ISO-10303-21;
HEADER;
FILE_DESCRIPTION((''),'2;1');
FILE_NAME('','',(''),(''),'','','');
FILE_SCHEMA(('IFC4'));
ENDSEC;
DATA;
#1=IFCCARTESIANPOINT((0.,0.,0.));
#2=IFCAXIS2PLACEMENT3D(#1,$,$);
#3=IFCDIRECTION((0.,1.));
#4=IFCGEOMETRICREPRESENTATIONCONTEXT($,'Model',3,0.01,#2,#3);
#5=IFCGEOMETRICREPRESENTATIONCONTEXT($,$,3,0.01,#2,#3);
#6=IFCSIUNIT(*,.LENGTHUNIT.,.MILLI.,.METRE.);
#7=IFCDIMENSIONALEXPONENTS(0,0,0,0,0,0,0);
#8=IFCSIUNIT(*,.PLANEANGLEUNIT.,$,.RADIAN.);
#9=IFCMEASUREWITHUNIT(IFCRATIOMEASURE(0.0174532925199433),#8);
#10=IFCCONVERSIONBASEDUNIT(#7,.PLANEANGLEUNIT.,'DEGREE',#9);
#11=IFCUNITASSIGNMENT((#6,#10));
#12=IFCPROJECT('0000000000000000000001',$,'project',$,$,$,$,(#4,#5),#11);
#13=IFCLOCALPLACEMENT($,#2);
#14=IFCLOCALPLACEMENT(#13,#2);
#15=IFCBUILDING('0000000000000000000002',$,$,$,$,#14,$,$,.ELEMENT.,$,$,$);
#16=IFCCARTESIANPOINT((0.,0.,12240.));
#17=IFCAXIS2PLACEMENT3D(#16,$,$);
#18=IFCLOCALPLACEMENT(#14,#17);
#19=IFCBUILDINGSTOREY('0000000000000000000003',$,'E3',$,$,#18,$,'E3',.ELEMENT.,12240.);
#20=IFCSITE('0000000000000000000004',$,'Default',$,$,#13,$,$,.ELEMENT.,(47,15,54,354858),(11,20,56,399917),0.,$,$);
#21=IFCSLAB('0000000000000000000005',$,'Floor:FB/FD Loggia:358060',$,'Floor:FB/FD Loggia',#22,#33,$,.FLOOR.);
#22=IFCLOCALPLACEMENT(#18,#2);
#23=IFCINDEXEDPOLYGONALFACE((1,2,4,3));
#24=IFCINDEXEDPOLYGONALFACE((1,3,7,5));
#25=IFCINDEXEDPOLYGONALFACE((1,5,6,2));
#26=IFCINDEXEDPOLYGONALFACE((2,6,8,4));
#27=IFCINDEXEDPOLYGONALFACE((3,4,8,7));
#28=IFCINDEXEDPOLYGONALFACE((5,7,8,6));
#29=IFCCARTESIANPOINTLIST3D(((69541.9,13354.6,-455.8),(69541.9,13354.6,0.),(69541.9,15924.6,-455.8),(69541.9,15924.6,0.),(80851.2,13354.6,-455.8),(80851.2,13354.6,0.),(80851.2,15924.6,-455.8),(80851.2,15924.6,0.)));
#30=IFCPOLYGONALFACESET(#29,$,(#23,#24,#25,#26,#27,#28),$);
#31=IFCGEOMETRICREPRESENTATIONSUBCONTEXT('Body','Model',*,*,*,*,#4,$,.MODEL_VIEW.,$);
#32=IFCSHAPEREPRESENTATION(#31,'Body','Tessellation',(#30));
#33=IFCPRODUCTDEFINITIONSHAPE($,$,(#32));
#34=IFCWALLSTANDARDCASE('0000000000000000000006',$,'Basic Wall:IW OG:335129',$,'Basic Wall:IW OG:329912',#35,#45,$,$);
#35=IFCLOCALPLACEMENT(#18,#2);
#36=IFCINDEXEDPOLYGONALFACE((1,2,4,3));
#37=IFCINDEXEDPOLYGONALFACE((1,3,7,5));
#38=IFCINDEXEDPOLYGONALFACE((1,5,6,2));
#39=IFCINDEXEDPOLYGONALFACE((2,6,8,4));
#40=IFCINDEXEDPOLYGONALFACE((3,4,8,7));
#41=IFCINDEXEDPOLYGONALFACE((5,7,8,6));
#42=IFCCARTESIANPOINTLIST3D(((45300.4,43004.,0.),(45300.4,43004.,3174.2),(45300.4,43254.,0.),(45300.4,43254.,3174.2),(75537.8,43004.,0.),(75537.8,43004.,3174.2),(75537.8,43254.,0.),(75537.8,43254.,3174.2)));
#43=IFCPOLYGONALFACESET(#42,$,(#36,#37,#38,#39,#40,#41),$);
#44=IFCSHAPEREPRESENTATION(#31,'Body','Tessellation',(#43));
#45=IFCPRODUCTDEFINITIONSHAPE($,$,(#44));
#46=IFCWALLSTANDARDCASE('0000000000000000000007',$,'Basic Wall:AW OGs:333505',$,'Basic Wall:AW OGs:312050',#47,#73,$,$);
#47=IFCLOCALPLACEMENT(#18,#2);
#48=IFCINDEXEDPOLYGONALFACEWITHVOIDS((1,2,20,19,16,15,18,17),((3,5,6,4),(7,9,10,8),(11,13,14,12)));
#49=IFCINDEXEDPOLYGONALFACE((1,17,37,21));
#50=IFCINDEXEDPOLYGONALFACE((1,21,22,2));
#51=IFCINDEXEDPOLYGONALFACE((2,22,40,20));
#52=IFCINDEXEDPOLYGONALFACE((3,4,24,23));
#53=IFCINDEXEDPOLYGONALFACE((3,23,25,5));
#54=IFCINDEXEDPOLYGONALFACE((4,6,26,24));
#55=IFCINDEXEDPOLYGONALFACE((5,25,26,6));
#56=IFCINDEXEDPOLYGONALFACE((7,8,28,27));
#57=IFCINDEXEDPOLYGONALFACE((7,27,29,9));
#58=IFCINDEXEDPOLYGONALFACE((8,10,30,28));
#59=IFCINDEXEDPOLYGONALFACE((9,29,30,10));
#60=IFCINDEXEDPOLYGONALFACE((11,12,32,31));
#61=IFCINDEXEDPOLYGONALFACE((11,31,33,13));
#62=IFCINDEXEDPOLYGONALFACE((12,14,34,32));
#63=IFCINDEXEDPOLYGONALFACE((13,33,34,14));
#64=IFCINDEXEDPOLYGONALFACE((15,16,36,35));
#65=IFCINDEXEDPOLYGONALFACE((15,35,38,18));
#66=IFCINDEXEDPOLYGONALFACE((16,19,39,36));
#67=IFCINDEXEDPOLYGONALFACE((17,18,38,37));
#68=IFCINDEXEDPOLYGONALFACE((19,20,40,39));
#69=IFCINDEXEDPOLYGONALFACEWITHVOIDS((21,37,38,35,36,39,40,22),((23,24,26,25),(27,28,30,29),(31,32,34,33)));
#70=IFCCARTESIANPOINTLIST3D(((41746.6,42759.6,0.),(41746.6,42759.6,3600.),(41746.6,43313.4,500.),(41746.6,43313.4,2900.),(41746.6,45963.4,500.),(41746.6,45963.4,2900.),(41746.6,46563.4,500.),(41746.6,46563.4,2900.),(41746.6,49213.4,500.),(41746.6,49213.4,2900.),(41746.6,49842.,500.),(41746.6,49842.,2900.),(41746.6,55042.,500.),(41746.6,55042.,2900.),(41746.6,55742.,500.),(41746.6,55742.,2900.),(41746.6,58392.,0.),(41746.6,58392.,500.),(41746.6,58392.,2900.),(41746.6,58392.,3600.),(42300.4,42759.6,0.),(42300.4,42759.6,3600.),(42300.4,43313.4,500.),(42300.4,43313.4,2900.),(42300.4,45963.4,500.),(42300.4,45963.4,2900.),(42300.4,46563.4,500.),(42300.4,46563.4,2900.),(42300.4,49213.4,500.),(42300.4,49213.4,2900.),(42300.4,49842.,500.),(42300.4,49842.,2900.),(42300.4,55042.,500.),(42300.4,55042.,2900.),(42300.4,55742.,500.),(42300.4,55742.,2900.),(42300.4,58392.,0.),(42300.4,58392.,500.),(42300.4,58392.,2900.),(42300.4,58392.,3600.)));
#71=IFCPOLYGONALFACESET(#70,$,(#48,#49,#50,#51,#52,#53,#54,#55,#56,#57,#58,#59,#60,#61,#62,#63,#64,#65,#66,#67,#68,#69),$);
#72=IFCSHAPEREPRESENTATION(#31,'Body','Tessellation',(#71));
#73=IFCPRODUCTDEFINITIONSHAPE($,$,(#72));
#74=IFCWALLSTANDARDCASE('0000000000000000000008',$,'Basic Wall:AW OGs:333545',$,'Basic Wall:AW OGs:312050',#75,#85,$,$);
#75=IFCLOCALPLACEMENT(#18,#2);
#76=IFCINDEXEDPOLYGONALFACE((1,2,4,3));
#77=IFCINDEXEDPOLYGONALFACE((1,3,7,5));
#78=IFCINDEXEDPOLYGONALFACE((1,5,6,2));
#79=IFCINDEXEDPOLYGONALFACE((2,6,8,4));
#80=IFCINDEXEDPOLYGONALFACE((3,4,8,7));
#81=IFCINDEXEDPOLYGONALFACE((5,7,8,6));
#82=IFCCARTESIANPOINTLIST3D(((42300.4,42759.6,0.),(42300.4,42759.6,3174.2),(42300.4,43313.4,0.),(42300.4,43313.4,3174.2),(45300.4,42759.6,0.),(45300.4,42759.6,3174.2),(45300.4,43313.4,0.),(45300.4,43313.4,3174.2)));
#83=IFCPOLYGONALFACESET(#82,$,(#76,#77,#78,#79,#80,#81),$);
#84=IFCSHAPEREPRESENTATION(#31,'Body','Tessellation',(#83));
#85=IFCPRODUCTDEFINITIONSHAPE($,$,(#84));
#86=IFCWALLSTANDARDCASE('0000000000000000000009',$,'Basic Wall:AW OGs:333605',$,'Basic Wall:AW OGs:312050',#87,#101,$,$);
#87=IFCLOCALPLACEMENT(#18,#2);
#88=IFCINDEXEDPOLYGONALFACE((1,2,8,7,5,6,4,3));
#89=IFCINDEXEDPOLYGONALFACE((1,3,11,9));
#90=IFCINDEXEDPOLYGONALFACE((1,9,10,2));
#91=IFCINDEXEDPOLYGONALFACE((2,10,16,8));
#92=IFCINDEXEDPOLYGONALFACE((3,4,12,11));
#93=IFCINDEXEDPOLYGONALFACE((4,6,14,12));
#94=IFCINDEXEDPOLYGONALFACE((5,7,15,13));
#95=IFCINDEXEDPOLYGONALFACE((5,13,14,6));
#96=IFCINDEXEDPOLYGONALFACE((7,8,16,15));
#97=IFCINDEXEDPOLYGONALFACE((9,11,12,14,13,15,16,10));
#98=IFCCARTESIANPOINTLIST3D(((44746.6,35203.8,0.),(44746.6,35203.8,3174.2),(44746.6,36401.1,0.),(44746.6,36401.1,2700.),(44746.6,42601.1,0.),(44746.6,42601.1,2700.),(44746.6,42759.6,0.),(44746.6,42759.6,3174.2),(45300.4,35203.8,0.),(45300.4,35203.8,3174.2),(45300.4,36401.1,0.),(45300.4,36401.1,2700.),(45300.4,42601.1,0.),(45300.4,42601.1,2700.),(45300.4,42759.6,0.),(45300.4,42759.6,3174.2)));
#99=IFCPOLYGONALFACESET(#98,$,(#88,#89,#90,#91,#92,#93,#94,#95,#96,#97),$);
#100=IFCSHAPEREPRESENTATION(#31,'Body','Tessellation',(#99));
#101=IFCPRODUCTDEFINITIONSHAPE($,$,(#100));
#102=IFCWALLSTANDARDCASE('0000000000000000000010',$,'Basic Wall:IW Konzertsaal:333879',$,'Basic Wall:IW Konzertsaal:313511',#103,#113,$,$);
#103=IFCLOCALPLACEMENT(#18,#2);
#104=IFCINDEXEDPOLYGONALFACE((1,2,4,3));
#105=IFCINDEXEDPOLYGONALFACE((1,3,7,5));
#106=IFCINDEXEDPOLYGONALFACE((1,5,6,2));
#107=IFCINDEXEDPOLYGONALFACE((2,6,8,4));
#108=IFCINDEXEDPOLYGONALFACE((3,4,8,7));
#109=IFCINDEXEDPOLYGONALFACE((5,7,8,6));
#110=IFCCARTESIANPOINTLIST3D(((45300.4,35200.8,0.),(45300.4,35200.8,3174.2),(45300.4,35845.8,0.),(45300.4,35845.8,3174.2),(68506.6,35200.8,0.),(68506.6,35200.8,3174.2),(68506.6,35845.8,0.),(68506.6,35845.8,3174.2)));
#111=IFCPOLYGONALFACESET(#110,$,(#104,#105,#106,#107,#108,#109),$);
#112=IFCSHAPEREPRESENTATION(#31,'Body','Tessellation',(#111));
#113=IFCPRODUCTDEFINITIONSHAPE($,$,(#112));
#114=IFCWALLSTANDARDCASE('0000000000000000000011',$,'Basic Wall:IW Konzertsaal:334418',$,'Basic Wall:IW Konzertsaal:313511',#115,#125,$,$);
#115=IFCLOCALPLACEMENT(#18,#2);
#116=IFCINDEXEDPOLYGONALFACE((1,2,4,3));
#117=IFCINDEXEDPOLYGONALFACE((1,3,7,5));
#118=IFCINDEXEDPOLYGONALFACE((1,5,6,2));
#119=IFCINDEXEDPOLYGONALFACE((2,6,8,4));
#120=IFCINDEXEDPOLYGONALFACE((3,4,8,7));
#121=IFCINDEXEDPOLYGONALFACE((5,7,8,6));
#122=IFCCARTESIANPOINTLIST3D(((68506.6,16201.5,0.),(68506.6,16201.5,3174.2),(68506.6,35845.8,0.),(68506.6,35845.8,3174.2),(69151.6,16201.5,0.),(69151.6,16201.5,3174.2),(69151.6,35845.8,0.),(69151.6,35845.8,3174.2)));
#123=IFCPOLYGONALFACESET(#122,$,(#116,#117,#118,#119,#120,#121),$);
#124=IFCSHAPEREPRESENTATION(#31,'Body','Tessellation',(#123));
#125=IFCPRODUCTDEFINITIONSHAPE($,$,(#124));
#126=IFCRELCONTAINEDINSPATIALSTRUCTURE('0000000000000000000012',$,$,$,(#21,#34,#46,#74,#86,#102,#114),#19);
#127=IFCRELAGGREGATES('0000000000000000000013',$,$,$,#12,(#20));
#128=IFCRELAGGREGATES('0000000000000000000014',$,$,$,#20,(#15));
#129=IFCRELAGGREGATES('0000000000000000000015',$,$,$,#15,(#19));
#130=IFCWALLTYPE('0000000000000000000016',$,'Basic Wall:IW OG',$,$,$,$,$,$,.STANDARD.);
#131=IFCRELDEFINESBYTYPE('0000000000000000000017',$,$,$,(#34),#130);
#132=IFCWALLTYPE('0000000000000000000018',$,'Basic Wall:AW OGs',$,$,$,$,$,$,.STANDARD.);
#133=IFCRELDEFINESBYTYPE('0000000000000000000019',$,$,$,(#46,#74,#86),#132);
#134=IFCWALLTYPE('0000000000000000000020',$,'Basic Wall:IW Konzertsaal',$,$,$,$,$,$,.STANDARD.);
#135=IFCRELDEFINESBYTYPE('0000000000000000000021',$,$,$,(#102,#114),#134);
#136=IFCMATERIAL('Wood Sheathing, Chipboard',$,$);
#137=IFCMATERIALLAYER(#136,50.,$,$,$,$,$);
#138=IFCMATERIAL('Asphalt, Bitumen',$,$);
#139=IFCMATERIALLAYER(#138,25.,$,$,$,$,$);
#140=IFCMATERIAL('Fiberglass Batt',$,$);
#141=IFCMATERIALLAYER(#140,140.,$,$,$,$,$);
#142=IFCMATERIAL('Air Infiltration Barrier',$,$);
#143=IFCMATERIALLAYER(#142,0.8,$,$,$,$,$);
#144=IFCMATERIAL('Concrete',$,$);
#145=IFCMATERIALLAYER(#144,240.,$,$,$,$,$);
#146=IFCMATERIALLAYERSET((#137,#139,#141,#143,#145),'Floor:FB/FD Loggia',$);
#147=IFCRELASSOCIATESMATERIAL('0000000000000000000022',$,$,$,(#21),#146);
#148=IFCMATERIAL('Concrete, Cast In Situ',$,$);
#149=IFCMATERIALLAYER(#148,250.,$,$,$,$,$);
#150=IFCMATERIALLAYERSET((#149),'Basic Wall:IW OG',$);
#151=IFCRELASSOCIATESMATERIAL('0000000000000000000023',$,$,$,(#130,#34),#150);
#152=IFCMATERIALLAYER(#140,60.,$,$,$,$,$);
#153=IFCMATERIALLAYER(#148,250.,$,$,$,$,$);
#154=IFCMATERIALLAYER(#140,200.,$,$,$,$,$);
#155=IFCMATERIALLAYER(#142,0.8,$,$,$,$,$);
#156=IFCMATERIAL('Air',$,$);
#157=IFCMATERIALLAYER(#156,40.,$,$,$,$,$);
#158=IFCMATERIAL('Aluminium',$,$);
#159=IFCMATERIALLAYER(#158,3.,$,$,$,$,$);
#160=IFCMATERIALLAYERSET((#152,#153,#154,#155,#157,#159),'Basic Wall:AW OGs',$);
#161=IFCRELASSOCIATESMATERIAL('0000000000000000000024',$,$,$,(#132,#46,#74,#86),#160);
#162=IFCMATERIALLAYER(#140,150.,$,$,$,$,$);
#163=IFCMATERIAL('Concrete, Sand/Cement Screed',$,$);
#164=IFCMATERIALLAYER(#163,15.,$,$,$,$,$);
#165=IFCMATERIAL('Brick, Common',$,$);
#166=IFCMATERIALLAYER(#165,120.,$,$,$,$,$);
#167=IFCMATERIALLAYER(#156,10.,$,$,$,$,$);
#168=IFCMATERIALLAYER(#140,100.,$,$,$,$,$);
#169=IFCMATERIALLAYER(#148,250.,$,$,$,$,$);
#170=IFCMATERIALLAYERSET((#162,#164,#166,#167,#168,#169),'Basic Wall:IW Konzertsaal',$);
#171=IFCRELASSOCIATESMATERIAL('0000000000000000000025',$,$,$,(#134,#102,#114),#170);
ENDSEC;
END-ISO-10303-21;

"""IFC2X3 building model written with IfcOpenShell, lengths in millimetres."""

from ifc_helpers import new_model, entity, si_unit, converted_unit, direction, frame, frame_2d, origin, place, context, subcontext, project, spatial, polyline, rectangle, extrude, clip, bounded_halfspace, material, layer, layer_set, layer_usage, type_object, element, save


model = new_model("IFC2X3")

# Units and contexts
model_context = context("Model", 3, precision=0.01, world=origin(), true_north=direction((0.0, 1.0)))
context_of_model = context(None, 3, precision=0.01, world=origin(), true_north=direction((0.0, 1.0)))
body_context = subcontext(model_context, "Body", "Model", "MODEL_VIEW")
ifc_project = project(units=[si_unit("LENGTHUNIT", "METRE", prefix="MILLI"), converted_unit("PLANEANGLEUNIT", "DEGREE", entity("IfcRatioMeasure", 0.0174532925199433), si_unit("PLANEANGLEUNIT", "RADIAN"), dimensions=[0, 0, 0, 0, 0, 0, 0])], contexts=[model_context, context_of_model])

# Site, building, storey
site_placement = place(None, origin())
site = spatial("IfcSite", under=ifc_project, at=site_placement, Name="Default", CompositionType="ELEMENT", RefLatitude=(47, 15, 54, 354858), RefLongitude=(11, 20, 56, 399917), RefElevation=0.0)
building_placement = place(site_placement, origin())
building = spatial("IfcBuilding", under=site, at=building_placement, CompositionType="ELEMENT")
storey_placement = place(building_placement, frame((0.0, 0.0, 12240.0)))
storey = spatial("IfcBuildingStorey", under=building, at=storey_placement, Name="E3", LongName="E3", CompositionType="ELEMENT", Elevation=12240.0)

# Slab
ifc_material_1 = material(Name="Concrete, Sand/Cement Screed")
ifc_material_2 = material(Name="Air Infiltration Barrier")
ifc_material_3 = material(Name="Fiberglass Batt")
ifc_material_4 = material(Name="Concrete")
ifc_material_5 = material(Name="Wood Sheathing, Chipboard")
ifc_layer_1 = layer(ifc_material_5, 50.0)
ifc_material_6 = material(Name="Asphalt, Bitumen")
ifc_layer_2 = layer(ifc_material_6, 25.0)
ifc_layer_3 = layer(ifc_material_3, 140.0)
ifc_layer_4 = layer(ifc_material_2, 0.8)
ifc_layer_5 = layer(ifc_material_4, 240.0)
ifc_layer_set_1 = layer_set([ifc_layer_1, ifc_layer_2, ifc_layer_3, ifc_layer_4, ifc_layer_5], Name="Floor:FB/FD Loggia")
ifc_layer_usage_1 = layer_usage(ifc_layer_set_1, "AXIS3", "POSITIVE", 0.0)
slab_1_placement = place(storey_placement, origin())
element("IfcSlab", 1, at=slab_1_placement, inside=storey, material=ifc_layer_usage_1, Name="Floor:FB/FD Loggia:358060", ObjectType="Floor:FB/FD Loggia", PredefinedType="FLOOR", context=body_context, shape_type="SweptSolid", body=[
    extrude(rectangle(XDim=2570.0, YDim=11309.3, at=frame_2d((0.0, 0.0), x_axis=(1.0, 0.0))), frame((75196.5, 14639.6, 0.0), z_axis=(0.0, 0.0, -1.0), x_axis=(0.0, 1.0, 0.0)), (0.0, 0.0, 1.0), 455.8),
])

# Wall
ifc_material_7 = material(Name="Concrete, Cast In Situ")
ifc_layer_6 = layer(ifc_material_7, 250.0)
ifc_layer_set_2 = layer_set([ifc_layer_6], Name="Basic Wall:IW OG")
ifc_layer_usage_2 = layer_usage(ifc_layer_set_2, "AXIS2", "POSITIVE", -125.0)
wall_type_1 = type_object("IfcWallType", Name="Basic Wall:IW OG", PredefinedType="STANDARD", material=ifc_layer_set_2)
wall_1_placement = place(storey_placement, frame((45300.4, 43129.0, 0.0)))
element("IfcWallStandardCase", 2, at=wall_1_placement, inside=storey, type_object=wall_type_1, material=ifc_layer_usage_2, Name="Basic Wall:IW OG:335129", ObjectType="Basic Wall:IW OG:329912", context=body_context, shape_type="Clipping", body=[
    clip(extrude(rectangle(XDim=30237.4, YDim=250.0, at=frame_2d((15118.7, 0.0), x_axis=(-1.0, 0.0))), origin(), (0.0, 0.0, 1.0), 3174.2), bounded_halfspace(frame((0.0, -125.0, 3174.2), z_axis=(0.0, 0.0, -1.0), x_axis=(0.0, -1.0, 0.0)), True, frame((0.0, -125.0, 3174.2)), polyline([(0.0, 0.0), (29987.4, 0.0), (30237.4, 0.0), (30237.4, 250.0), (0.0, 250.0), (0.0, 0.0)]))),
])

# Wall, openings
ifc_layer_7 = layer(ifc_material_3, 60.0)
ifc_layer_8 = layer(ifc_material_7, 250.0)
ifc_layer_9 = layer(ifc_material_3, 200.0)
ifc_layer_10 = layer(ifc_material_2, 0.8)
ifc_material_8 = material(Name="Air")
ifc_layer_11 = layer(ifc_material_8, 40.0)
ifc_material_9 = material(Name="Aluminium")
ifc_layer_12 = layer(ifc_material_9, 3.0)
ifc_layer_set_3 = layer_set([ifc_layer_7, ifc_layer_8, ifc_layer_9, ifc_layer_10, ifc_layer_11, ifc_layer_12], Name="Basic Wall:AW OGs")
ifc_layer_usage_3 = layer_usage(ifc_layer_set_3, "AXIS2", "NEGATIVE", 276.9)
wall_type_2 = type_object("IfcWallType", Name="Basic Wall:AW OGs", PredefinedType="STANDARD", material=ifc_layer_set_3)
wall_2_placement = place(storey_placement, frame((42023.5, 58392.0, 0.0), z_axis=(0.0, 0.0, 1.0), x_axis=(0.0, -1.0, 0.0)))
wall_2 = element("IfcWallStandardCase", 3, at=wall_2_placement, inside=storey, type_object=wall_type_2, material=ifc_layer_usage_3, Name="Basic Wall:AW OGs:333505", ObjectType="Basic Wall:AW OGs:312050", context=body_context, shape_type="SweptSolid", body=[
    extrude(rectangle(XDim=15632.4, YDim=553.8, at=frame_2d((7816.2, 0.0), x_axis=(-1.0, 0.0))), origin(), (0.0, 0.0, 1.0), 3600.0),
])
opening_1_placement = place(wall_2_placement, frame((2650.0, 276.9, 500.0)))
element("IfcOpeningElement", 4, at=opening_1_placement, cuts=wall_2, ObjectType="Opening", context=body_context, shape_type="SweptSolid", body=[
    extrude(rectangle(XDim=2400.0, YDim=2650.0, at=frame_2d((1200.0, 1325.0), x_axis=(-1.0, 0.0))), frame((0.0, 0.0, 0.0), z_axis=(0.0, -1.0, 0.0), x_axis=(0.0, 0.0, 1.0)), (0.0, 0.0, 1.0), 553.8),
])
opening_2_placement = place(wall_2_placement, frame((11828.6, 276.9, 500.0)))
element("IfcOpeningElement", 5, at=opening_2_placement, cuts=wall_2, ObjectType="Opening", context=body_context, shape_type="SweptSolid", body=[
    extrude(rectangle(XDim=2400.0, YDim=2650.0, at=frame_2d((1200.0, 1325.0), x_axis=(-1.0, 0.0))), frame((0.0, 0.0, 0.0), z_axis=(0.0, -1.0, 0.0), x_axis=(0.0, 0.0, 1.0)), (0.0, 0.0, 1.0), 553.8),
])
opening_3_placement = place(wall_2_placement, frame((8550.0, 276.9, 500.0)))
element("IfcOpeningElement", 6, at=opening_3_placement, cuts=wall_2, ObjectType="Opening", context=body_context, shape_type="SweptSolid", body=[
    extrude(rectangle(XDim=2400.0, YDim=5200.0, at=frame_2d((1200.0, 2600.0), x_axis=(-1.0, 0.0))), frame((0.0, 0.0, 0.0), z_axis=(0.0, -1.0, 0.0), x_axis=(0.0, 0.0, 1.0)), (0.0, 0.0, 1.0), 553.8),
])
opening_4_placement = place(wall_2_placement, frame((15078.6, 276.9, 500.0)))
element("IfcOpeningElement", 7, at=opening_4_placement, cuts=wall_2, ObjectType="Opening", context=body_context, shape_type="SweptSolid", body=[
    extrude(rectangle(XDim=2400.0, YDim=2650.0, at=frame_2d((1200.0, 1325.0), x_axis=(-1.0, 0.0))), frame((0.0, 0.0, 0.0), z_axis=(0.0, -1.0, 0.0), x_axis=(0.0, 0.0, 1.0)), (0.0, 0.0, 1.0), 553.8),
])

# Wall
ifc_layer_usage_4 = layer_usage(ifc_layer_set_3, "AXIS2", "NEGATIVE", 276.9)
wall_3_placement = place(storey_placement, frame((42300.4, 43036.5, 0.0)))
element("IfcWallStandardCase", 8, at=wall_3_placement, inside=storey, type_object=wall_type_2, material=ifc_layer_usage_4, Name="Basic Wall:AW OGs:333545", ObjectType="Basic Wall:AW OGs:312050", context=body_context, shape_type="Clipping", body=[
    clip(extrude(rectangle(XDim=3000.0, YDim=553.8, at=frame_2d((1500.0, 0.0), x_axis=(-1.0, 0.0))), origin(), (0.0, 0.0, 1.0), 3174.2), bounded_halfspace(frame((0.0, -276.9, 3174.2), z_axis=(0.0, 0.0, -1.0), x_axis=(0.0, -1.0, 0.0)), True, frame((0.0, -276.9, 3174.2)), polyline([(0.0, 0.0), (2446.2, 0.0), (3000.0, 0.0), (3000.0, 244.4), (3000.0, 494.4), (3000.0, 553.8), (0.0, 553.8), (0.0, 0.0)]))),
])

# Wall, opening
ifc_layer_usage_5 = layer_usage(ifc_layer_set_3, "AXIS2", "NEGATIVE", 276.9)
wall_4_placement = place(storey_placement, frame((45023.5, 42759.6, 0.0), z_axis=(0.0, 0.0, 1.0), x_axis=(0.0, -1.0, 0.0)))
wall_4 = element("IfcWallStandardCase", 9, at=wall_4_placement, inside=storey, type_object=wall_type_2, material=ifc_layer_usage_5, Name="Basic Wall:AW OGs:333605", ObjectType="Basic Wall:AW OGs:312050", context=body_context, shape_type="Clipping", body=[
    clip(extrude(rectangle(XDim=7555.9, YDim=553.8, at=frame_2d((3777.9, 0.0), x_axis=(-1.0, 0.0))), origin(), (0.0, 0.0, 1.0), 3174.2), bounded_halfspace(frame((0.0, -276.9, 3174.2), z_axis=(0.0, 0.0, -1.0), x_axis=(1.0, 0.0, 0.0)), True, frame((0.0, -276.9, 3174.2)), polyline([(0.0, 0.0), (6517.1, 0.0), (7555.9, 0.0), (7555.9, 553.8), (6913.8, 553.8), (0.0, 553.8), (0.0, 0.0)]))),
])
opening_5_placement = place(wall_4_placement, frame((6358.5, 276.9, 0.0)))
element("IfcOpeningElement", 10, at=opening_5_placement, cuts=wall_4, ObjectType="Opening", context=body_context, shape_type="SweptSolid", body=[
    extrude(rectangle(XDim=2700.0, YDim=6200.0, at=frame_2d((1350.0, 3100.0), x_axis=(-1.0, 0.0))), frame((0.0, 0.0, 0.0), z_axis=(0.0, -1.0, 0.0), x_axis=(0.0, 0.0, 1.0)), (0.0, 0.0, 1.0), 553.8),
])

# Walls
ifc_layer_13 = layer(ifc_material_3, 150.0)
ifc_layer_14 = layer(ifc_material_1, 15.0)
ifc_material_10 = material(Name="Brick, Common")
ifc_layer_15 = layer(ifc_material_10, 120.0)
ifc_layer_16 = layer(ifc_material_8, 10.0)
ifc_layer_17 = layer(ifc_material_3, 100.0)
ifc_layer_18 = layer(ifc_material_7, 250.0)
ifc_layer_set_4 = layer_set([ifc_layer_13, ifc_layer_14, ifc_layer_15, ifc_layer_16, ifc_layer_17, ifc_layer_18], Name="Basic Wall:IW Konzertsaal")
ifc_layer_usage_6 = layer_usage(ifc_layer_set_4, "AXIS2", "NEGATIVE", 322.5)
wall_type_3 = type_object("IfcWallType", Name="Basic Wall:IW Konzertsaal", PredefinedType="STANDARD", material=ifc_layer_set_4)
wall_5_placement = place(storey_placement, frame((68506.6, 35523.3, 0.0), z_axis=(0.0, 0.0, 1.0), x_axis=(-1.0, 0.0, 0.0)))
element("IfcWallStandardCase", 11, at=wall_5_placement, inside=storey, type_object=wall_type_3, material=ifc_layer_usage_6, Name="Basic Wall:IW Konzertsaal:333879", ObjectType="Basic Wall:IW Konzertsaal:313511", context=body_context, shape_type="Clipping", body=[
    clip(extrude(rectangle(XDim=23206.2, YDim=645.0, at=frame_2d((11603.1, 0.0), x_axis=(-1.0, 0.0))), origin(), (0.0, 0.0, 1.0), 3174.2), bounded_halfspace(frame((0.0, -322.5, 3174.2), z_axis=(0.0, 0.0, -1.0), x_axis=(0.0, 1.0, 0.0)), True, frame((0.0, -322.5, 3174.2)), polyline([(0.0, 0.0), (23206.2, 0.0), (23206.2, 642.1), (23206.2, 645.0), (0.0, 645.0), (0.0, 0.0)]))),
])
ifc_layer_usage_7 = layer_usage(ifc_layer_set_4, "AXIS2", "NEGATIVE", 322.5)
wall_6_placement = place(storey_placement, frame((68829.1, 16201.5, 0.0), z_axis=(0.0, 0.0, 1.0), x_axis=(0.0, 1.0, 0.0)))
element("IfcWallStandardCase", 12, at=wall_6_placement, inside=storey, type_object=wall_type_3, material=ifc_layer_usage_7, Name="Basic Wall:IW Konzertsaal:334418", ObjectType="Basic Wall:IW Konzertsaal:313511", context=body_context, shape_type="Clipping", body=[
    clip(extrude(rectangle(XDim=19644.3, YDim=645.0, at=frame_2d((9822.1, 0.0), x_axis=(-1.0, 0.0))), origin(), (0.0, 0.0, 1.0), 3174.2), bounded_halfspace(frame((0.0, -322.5, 3174.2), z_axis=(0.0, 0.0, -1.0), x_axis=(-1.0, 0.0, 0.0)), True, frame((0.0, -322.5, 3174.2)), polyline([(0.0, 0.0), (276.9, 0.0), (14428.1, 0.0), (14678.1, 0.0), (19644.3, 0.0), (19644.3, 645.0), (18999.3, 645.0), (0.0, 645.0), (0.0, 0.0)]))),
])

save(model, "model.ifc")
